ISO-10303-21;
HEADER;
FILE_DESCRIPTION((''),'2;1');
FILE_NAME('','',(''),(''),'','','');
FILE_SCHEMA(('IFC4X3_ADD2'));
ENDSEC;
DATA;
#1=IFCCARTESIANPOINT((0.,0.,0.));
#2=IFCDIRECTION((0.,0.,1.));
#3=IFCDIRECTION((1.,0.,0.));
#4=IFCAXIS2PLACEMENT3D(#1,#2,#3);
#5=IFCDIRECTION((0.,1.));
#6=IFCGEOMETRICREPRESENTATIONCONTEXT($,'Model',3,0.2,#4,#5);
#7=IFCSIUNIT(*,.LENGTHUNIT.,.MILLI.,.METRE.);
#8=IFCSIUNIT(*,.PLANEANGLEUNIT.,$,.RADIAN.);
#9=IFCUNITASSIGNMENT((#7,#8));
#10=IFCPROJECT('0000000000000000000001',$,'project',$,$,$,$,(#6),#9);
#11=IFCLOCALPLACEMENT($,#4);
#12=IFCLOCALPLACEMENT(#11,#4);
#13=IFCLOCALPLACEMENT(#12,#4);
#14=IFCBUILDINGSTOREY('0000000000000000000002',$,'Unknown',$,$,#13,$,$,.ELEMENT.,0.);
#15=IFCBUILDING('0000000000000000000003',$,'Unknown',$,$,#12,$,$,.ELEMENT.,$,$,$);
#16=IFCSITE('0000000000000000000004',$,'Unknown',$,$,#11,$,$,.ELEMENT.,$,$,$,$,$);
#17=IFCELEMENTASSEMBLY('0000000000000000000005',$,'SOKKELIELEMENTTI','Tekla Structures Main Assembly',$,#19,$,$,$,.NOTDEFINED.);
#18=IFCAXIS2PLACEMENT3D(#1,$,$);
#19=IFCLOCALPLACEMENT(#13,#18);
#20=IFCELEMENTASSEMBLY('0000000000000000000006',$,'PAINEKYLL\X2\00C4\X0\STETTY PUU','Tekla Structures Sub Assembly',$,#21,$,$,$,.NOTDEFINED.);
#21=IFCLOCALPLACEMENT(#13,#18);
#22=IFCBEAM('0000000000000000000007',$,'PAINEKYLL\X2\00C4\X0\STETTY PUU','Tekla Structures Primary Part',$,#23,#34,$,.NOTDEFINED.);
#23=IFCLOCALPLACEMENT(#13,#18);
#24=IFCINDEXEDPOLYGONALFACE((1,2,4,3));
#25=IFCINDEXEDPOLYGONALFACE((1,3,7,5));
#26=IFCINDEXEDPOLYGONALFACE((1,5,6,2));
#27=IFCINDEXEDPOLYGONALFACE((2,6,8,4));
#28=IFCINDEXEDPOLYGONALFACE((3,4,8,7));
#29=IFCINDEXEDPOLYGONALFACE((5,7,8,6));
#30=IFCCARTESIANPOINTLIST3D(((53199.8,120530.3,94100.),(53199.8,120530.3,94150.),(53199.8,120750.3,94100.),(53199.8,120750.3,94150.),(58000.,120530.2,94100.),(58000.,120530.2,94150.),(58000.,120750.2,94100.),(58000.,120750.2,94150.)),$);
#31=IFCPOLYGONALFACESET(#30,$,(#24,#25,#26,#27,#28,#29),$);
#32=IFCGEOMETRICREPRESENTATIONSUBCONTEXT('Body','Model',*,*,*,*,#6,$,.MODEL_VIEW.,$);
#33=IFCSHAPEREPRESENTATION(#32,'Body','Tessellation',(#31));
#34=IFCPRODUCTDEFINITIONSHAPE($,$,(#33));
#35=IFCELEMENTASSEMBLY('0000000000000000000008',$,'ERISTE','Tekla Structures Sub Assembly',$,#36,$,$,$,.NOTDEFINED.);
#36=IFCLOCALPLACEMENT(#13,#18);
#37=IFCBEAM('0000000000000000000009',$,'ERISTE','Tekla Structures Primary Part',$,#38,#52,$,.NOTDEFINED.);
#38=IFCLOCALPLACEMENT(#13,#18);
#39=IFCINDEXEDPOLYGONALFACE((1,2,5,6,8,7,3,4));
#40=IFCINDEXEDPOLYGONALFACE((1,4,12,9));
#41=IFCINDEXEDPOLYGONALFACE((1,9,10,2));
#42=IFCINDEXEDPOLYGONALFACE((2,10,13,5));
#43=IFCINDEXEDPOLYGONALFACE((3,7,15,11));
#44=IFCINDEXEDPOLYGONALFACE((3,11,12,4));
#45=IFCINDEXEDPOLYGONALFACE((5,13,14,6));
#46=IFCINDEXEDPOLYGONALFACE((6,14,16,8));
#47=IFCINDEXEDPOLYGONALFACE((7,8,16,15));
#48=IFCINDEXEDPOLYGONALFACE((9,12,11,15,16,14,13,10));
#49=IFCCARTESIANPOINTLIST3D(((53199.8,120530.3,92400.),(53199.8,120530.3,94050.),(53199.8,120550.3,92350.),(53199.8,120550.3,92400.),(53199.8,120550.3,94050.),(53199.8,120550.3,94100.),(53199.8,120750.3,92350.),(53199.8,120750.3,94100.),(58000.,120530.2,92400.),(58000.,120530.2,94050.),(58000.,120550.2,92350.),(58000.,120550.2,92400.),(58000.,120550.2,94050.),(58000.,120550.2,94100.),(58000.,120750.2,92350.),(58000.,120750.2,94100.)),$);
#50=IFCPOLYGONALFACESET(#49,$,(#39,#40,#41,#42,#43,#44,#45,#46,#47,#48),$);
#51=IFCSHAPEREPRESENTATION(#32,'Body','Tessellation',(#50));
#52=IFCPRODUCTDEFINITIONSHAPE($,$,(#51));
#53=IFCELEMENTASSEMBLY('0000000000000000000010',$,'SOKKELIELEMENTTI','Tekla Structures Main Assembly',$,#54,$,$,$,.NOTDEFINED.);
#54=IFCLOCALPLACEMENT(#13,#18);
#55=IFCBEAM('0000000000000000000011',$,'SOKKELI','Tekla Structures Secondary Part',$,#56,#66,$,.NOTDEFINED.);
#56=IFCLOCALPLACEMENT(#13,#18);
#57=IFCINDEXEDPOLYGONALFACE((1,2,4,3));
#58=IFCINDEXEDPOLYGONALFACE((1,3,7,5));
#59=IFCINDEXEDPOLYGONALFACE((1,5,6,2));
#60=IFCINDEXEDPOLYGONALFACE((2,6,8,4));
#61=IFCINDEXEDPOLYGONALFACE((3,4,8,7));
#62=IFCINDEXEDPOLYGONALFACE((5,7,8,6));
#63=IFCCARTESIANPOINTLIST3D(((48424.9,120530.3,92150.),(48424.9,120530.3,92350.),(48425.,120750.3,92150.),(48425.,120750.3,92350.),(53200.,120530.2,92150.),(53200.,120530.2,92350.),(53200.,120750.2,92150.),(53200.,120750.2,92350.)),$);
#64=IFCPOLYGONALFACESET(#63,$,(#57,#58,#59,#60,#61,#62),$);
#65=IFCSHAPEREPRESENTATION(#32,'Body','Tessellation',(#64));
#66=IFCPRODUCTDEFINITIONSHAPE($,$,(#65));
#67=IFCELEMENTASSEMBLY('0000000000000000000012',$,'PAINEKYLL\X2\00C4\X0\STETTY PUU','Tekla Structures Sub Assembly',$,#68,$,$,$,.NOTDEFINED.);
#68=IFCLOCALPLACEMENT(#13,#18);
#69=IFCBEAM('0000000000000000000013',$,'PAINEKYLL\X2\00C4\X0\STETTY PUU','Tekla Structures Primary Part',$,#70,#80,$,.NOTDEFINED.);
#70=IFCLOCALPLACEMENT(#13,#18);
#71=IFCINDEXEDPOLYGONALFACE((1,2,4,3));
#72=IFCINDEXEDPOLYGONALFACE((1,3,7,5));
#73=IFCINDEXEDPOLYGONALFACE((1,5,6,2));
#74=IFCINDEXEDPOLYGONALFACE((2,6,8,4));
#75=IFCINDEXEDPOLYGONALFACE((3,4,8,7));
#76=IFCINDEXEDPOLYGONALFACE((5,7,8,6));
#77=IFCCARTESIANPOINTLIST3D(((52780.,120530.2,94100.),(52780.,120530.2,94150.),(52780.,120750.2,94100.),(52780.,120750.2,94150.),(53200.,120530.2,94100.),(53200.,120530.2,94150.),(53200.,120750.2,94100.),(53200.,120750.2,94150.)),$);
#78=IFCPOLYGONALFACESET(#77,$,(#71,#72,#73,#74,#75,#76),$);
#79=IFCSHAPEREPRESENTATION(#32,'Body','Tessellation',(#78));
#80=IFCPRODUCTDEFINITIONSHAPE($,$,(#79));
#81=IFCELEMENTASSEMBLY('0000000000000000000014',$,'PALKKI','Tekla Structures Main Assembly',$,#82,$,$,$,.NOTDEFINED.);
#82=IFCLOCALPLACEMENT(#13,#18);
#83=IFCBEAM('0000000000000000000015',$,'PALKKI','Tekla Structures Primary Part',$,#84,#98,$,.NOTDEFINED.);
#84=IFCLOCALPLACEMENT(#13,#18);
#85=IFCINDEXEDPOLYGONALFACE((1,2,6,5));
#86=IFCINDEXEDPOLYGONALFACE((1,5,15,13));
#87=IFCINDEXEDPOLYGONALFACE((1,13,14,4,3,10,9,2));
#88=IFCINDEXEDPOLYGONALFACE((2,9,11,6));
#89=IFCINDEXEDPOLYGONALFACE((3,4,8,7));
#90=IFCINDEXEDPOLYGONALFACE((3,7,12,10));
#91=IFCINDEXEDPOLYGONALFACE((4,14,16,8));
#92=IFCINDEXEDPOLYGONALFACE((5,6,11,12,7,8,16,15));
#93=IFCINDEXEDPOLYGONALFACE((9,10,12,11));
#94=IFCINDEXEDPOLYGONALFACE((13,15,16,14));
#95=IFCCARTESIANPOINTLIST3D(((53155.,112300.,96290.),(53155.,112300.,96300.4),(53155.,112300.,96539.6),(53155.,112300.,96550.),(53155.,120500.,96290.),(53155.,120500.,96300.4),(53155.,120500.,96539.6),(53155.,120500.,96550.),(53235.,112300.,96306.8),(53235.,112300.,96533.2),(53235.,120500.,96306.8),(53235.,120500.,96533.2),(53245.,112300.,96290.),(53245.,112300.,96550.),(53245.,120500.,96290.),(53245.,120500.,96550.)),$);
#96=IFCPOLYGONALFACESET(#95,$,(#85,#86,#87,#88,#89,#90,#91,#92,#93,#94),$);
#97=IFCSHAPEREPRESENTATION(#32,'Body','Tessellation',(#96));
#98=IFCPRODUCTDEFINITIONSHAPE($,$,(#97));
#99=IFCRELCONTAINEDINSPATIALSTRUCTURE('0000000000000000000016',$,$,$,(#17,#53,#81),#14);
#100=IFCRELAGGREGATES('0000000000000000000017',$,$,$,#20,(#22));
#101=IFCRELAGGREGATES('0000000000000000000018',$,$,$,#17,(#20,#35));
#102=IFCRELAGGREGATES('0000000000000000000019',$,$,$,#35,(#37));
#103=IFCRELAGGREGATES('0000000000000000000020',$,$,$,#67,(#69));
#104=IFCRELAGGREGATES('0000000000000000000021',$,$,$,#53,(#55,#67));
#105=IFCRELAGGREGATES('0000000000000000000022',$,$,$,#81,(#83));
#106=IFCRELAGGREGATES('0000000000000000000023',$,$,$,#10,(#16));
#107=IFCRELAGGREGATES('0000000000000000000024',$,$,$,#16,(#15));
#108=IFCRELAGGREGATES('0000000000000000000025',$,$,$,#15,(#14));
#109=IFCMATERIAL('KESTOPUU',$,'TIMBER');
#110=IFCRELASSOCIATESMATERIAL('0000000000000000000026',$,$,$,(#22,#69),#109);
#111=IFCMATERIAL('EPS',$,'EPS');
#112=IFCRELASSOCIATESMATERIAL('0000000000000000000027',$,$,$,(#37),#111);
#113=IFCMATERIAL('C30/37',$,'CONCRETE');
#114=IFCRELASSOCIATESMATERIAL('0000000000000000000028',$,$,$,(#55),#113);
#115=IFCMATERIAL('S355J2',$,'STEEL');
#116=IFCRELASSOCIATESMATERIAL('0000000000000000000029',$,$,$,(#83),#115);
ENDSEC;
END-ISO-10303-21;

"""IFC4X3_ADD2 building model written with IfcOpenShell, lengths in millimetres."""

from ifc_helpers import new_model, si_unit, direction, frame, origin_with_axes, place, context, subcontext, project, spatial, line, indexed_curve, outline, extrude, material, element, aggregate, save


model = new_model("IFC4X3_ADD2")

# Units and contexts
model_context = context("Model", 3, precision=0.2, world=origin_with_axes(), true_north=direction((0.0, 1.0)))
body_context = subcontext(model_context, "Body", "Model", "MODEL_VIEW")
ifc_project = project(units=[si_unit("LENGTHUNIT", "METRE", prefix="MILLI"), si_unit("PLANEANGLEUNIT", "RADIAN")], contexts=[model_context])

# Site, building, storey
site_placement = place(None, origin_with_axes())
site = spatial("IfcSite", under=ifc_project, at=site_placement, Name="Unknown", CompositionType="ELEMENT")
building_placement = place(site_placement, origin_with_axes())
building = spatial("IfcBuilding", under=site, at=building_placement, Name="Unknown", CompositionType="ELEMENT")
storey_placement = place(building_placement, origin_with_axes())
storey = spatial("IfcBuildingStorey", under=building, at=storey_placement, Name="Unknown", CompositionType="ELEMENT", Elevation=0.0)

# Shared definitions
ifc_material_1 = material(Name="C30/37", Category="CONCRETE")

# Element assemblies, beams, voiding features
assembly_1_placement = place(storey_placement, frame((58000.0, 120810.2, 93150.0), z_axis=(0.000027, 1.0, 0.0), x_axis=(-1.0, 0.000027, 0.0)))
assembly_1 = element("IfcElementAssembly", 1, at=assembly_1_placement, inside=storey, Name="SOKKELIELEMENTTI", Description="Tekla Structures Main Assembly", PredefinedType="NOTDEFINED")
assembly_2_placement = place(assembly_1_placement, frame((0.0, 975.0, -170.0), z_axis=(0.0, -1.0, 0.0), x_axis=(1.0, 0.0, 0.0)))
assembly_2 = element("IfcElementAssembly", 2, at=assembly_2_placement, Name="PAINEKYLLÄSTETTY PUU", Description="Tekla Structures Sub Assembly", PredefinedType="NOTDEFINED")
ifc_material_2 = material(Name="KESTOPUU", Category="TIMBER")
beam_1_placement = place(assembly_2_placement, origin_with_axes())
beam_1 = element("IfcBeam", 3, at=beam_1_placement, material=ifc_material_2, Name="PAINEKYLLÄSTETTY PUU", Description="Tekla Structures Primary Part", PredefinedType="NOTDEFINED", context=body_context, shape_type="SolidModel", body=[
    extrude(outline(indexed_curve([(-25.0, -110.0), (25.0, -110.0), (25.0, 110.0), (-25.0, 110.0)], segments=[line(1, 2, 3, 4, 1)])), frame((0.0, 0.0, 0.0), z_axis=(-1.0, 0.0, 0.0), x_axis=(0.0, 0.0, 1.0)), (0.0, 0.0, -1.0), 4800.1),
])
aggregate(assembly_2, [beam_1])
assembly_3_placement = place(assembly_1_placement, frame((0.0, 75.0, -170.0), z_axis=(0.0, 0.0, 1.0), x_axis=(1.0, 0.0, 0.0)))
assembly_3 = element("IfcElementAssembly", 4, at=assembly_3_placement, Name="ERISTE", Description="Tekla Structures Sub Assembly", PredefinedType="NOTDEFINED")
aggregate(assembly_1, [assembly_2, assembly_3])
ifc_material_3 = material(Name="EPS", Category="EPS")
beam_2_placement = place(assembly_3_placement, origin_with_axes())
beam_2 = element("IfcBeam", 5, at=beam_2_placement, material=ifc_material_3, Name="ERISTE", Description="Tekla Structures Primary Part", PredefinedType="NOTDEFINED", context=body_context, shape_type="SolidModel", body=[
    extrude(outline(indexed_curve([(-110.0, -875.0), (110.0, -875.0), (110.0, 875.0), (-110.0, 875.0)], segments=[line(1, 2, 3, 4, 1)])), frame((0.0, 0.0, 0.0), z_axis=(-1.0, 0.0, 0.0), x_axis=(0.0, 0.0, 1.0)), (0.0, 0.0, -1.0), 4800.1),
])
voiding_feature_1_placement = place(beam_2_placement, frame((-1.0, 850.0, -100.0), z_axis=(0.0, 0.0, 1.0), x_axis=(1.0, 0.0, 0.0)))
element("IfcVoidingFeature", 6, at=voiding_feature_1_placement, cuts=beam_2, PredefinedType="HOLE", context=body_context, shape_type="SolidModel", body=[
    extrude(outline(indexed_curve([(-10.0, -25.0), (10.0, -25.0), (10.0, 25.0), (-10.0, 25.0)], segments=[line(1, 2, 3, 4, 1)])), frame((0.0, 0.0, 0.0), z_axis=(-1.0, 0.0, 0.0), x_axis=(0.0, 0.0, 1.0)), (0.0, 0.0, -1.0), 4802.1),
])
voiding_feature_2_placement = place(beam_2_placement, frame((-1.0, -850.0, -100.0), z_axis=(0.0, 0.0, 1.0), x_axis=(1.0, 0.0, 0.0)))
element("IfcVoidingFeature", 7, at=voiding_feature_2_placement, cuts=beam_2, PredefinedType="HOLE", context=body_context, shape_type="SolidModel", body=[
    extrude(outline(indexed_curve([(-10.0, -25.0), (10.0, -25.0), (10.0, 25.0), (-10.0, 25.0)], segments=[line(1, 2, 3, 4, 1)])), frame((0.0, 0.0, 0.0), z_axis=(-1.0, 0.0, 0.0), x_axis=(0.0, 0.0, 1.0)), (0.0, 0.0, -1.0), 4802.1),
])
aggregate(assembly_3, [beam_2])
assembly_4_placement = place(storey_placement, frame((53200.0, 120810.2, 93150.0), z_axis=(0.000031, 1.0, 0.0), x_axis=(-1.0, 0.000031, 0.0)))
assembly_4 = element("IfcElementAssembly", 8, at=assembly_4_placement, inside=storey, Name="SOKKELIELEMENTTI", Description="Tekla Structures Main Assembly", PredefinedType="NOTDEFINED")
beam_3_placement = place(assembly_4_placement, frame((0.0, -900.0, -170.0), z_axis=(0.0, 0.0, 1.0), x_axis=(1.0, 0.0, 0.0)))
beam_3 = element("IfcBeam", 9, at=beam_3_placement, material=ifc_material_1, Name="SOKKELI", Description="Tekla Structures Secondary Part", PredefinedType="NOTDEFINED", context=body_context, shape_type="SolidModel", body=[
    extrude(outline(indexed_curve([(-110.0, -100.0), (110.0, -100.0), (110.0, 100.0), (-110.0, 100.0)], segments=[line(1, 2, 3, 4, 1)])), frame((0.0, 0.0, 0.0), z_axis=(-1.0, 0.0, 0.0), x_axis=(0.0, 0.0, 1.0)), (0.0, 0.0, -1.0), 4775.0),
])
assembly_5_placement = place(assembly_4_placement, frame((0.0, 975.0, -170.0), z_axis=(0.0, -1.0, 0.0), x_axis=(1.0, 0.0, 0.0)))
assembly_5 = element("IfcElementAssembly", 10, at=assembly_5_placement, Name="PAINEKYLLÄSTETTY PUU", Description="Tekla Structures Sub Assembly", PredefinedType="NOTDEFINED")
beam_4_placement = place(assembly_5_placement, origin_with_axes())
beam_4 = element("IfcBeam", 11, at=beam_4_placement, material=ifc_material_2, Name="PAINEKYLLÄSTETTY PUU", Description="Tekla Structures Primary Part", PredefinedType="NOTDEFINED", context=body_context, shape_type="SolidModel", body=[
    extrude(outline(indexed_curve([(-25.0, -110.0), (25.0, -110.0), (25.0, 110.0), (-25.0, 110.0)], segments=[line(1, 2, 3, 4, 1)])), frame((0.0, 0.0, 0.0), z_axis=(-1.0, 0.0, 0.0), x_axis=(0.0, 0.0, 1.0)), (0.0, 0.0, -1.0), 420.0),
])
aggregate(assembly_5, [beam_4])
aggregate(assembly_4, [beam_3, assembly_5])

# Element assembly, beam
assembly_6_placement = place(storey_placement, frame((53200.0, 120500.0, 96420.0), z_axis=(-1.0, 0.0, 0.0), x_axis=(0.0, -1.0, 0.0)))
assembly_6 = element("IfcElementAssembly", 12, at=assembly_6_placement, inside=storey, Name="PALKKI", Description="Tekla Structures Main Assembly", PredefinedType="NOTDEFINED")
ifc_material_4 = material(Name="S355J2", Category="STEEL")
beam_5_placement = place(assembly_6_placement, origin_with_axes())
beam_5 = element("IfcBeam", 13, at=beam_5_placement, material=ifc_material_4, Name="PALKKI", Description="Tekla Structures Primary Part", PredefinedType="NOTDEFINED", context=body_context, shape_type="SolidModel", body=[
    extrude(outline(indexed_curve([(-45.0, -130.0), (45.0, -130.0), (45.0, -119.6), (-35.0, -113.2), (-35.0, 113.2), (45.0, 119.6), (45.0, 130.0), (-45.0, 130.0)], segments=[line(1, 2, 3, 4, 5, 6, 7, 8, 1)])), frame((0.0, 0.0, 0.0), z_axis=(-1.0, 0.0, 0.0), x_axis=(0.0, 0.0, 1.0)), (0.0, 0.0, -1.0), 8200.0),
])
aggregate(assembly_6, [beam_5])

save(model, "model.ifc")
